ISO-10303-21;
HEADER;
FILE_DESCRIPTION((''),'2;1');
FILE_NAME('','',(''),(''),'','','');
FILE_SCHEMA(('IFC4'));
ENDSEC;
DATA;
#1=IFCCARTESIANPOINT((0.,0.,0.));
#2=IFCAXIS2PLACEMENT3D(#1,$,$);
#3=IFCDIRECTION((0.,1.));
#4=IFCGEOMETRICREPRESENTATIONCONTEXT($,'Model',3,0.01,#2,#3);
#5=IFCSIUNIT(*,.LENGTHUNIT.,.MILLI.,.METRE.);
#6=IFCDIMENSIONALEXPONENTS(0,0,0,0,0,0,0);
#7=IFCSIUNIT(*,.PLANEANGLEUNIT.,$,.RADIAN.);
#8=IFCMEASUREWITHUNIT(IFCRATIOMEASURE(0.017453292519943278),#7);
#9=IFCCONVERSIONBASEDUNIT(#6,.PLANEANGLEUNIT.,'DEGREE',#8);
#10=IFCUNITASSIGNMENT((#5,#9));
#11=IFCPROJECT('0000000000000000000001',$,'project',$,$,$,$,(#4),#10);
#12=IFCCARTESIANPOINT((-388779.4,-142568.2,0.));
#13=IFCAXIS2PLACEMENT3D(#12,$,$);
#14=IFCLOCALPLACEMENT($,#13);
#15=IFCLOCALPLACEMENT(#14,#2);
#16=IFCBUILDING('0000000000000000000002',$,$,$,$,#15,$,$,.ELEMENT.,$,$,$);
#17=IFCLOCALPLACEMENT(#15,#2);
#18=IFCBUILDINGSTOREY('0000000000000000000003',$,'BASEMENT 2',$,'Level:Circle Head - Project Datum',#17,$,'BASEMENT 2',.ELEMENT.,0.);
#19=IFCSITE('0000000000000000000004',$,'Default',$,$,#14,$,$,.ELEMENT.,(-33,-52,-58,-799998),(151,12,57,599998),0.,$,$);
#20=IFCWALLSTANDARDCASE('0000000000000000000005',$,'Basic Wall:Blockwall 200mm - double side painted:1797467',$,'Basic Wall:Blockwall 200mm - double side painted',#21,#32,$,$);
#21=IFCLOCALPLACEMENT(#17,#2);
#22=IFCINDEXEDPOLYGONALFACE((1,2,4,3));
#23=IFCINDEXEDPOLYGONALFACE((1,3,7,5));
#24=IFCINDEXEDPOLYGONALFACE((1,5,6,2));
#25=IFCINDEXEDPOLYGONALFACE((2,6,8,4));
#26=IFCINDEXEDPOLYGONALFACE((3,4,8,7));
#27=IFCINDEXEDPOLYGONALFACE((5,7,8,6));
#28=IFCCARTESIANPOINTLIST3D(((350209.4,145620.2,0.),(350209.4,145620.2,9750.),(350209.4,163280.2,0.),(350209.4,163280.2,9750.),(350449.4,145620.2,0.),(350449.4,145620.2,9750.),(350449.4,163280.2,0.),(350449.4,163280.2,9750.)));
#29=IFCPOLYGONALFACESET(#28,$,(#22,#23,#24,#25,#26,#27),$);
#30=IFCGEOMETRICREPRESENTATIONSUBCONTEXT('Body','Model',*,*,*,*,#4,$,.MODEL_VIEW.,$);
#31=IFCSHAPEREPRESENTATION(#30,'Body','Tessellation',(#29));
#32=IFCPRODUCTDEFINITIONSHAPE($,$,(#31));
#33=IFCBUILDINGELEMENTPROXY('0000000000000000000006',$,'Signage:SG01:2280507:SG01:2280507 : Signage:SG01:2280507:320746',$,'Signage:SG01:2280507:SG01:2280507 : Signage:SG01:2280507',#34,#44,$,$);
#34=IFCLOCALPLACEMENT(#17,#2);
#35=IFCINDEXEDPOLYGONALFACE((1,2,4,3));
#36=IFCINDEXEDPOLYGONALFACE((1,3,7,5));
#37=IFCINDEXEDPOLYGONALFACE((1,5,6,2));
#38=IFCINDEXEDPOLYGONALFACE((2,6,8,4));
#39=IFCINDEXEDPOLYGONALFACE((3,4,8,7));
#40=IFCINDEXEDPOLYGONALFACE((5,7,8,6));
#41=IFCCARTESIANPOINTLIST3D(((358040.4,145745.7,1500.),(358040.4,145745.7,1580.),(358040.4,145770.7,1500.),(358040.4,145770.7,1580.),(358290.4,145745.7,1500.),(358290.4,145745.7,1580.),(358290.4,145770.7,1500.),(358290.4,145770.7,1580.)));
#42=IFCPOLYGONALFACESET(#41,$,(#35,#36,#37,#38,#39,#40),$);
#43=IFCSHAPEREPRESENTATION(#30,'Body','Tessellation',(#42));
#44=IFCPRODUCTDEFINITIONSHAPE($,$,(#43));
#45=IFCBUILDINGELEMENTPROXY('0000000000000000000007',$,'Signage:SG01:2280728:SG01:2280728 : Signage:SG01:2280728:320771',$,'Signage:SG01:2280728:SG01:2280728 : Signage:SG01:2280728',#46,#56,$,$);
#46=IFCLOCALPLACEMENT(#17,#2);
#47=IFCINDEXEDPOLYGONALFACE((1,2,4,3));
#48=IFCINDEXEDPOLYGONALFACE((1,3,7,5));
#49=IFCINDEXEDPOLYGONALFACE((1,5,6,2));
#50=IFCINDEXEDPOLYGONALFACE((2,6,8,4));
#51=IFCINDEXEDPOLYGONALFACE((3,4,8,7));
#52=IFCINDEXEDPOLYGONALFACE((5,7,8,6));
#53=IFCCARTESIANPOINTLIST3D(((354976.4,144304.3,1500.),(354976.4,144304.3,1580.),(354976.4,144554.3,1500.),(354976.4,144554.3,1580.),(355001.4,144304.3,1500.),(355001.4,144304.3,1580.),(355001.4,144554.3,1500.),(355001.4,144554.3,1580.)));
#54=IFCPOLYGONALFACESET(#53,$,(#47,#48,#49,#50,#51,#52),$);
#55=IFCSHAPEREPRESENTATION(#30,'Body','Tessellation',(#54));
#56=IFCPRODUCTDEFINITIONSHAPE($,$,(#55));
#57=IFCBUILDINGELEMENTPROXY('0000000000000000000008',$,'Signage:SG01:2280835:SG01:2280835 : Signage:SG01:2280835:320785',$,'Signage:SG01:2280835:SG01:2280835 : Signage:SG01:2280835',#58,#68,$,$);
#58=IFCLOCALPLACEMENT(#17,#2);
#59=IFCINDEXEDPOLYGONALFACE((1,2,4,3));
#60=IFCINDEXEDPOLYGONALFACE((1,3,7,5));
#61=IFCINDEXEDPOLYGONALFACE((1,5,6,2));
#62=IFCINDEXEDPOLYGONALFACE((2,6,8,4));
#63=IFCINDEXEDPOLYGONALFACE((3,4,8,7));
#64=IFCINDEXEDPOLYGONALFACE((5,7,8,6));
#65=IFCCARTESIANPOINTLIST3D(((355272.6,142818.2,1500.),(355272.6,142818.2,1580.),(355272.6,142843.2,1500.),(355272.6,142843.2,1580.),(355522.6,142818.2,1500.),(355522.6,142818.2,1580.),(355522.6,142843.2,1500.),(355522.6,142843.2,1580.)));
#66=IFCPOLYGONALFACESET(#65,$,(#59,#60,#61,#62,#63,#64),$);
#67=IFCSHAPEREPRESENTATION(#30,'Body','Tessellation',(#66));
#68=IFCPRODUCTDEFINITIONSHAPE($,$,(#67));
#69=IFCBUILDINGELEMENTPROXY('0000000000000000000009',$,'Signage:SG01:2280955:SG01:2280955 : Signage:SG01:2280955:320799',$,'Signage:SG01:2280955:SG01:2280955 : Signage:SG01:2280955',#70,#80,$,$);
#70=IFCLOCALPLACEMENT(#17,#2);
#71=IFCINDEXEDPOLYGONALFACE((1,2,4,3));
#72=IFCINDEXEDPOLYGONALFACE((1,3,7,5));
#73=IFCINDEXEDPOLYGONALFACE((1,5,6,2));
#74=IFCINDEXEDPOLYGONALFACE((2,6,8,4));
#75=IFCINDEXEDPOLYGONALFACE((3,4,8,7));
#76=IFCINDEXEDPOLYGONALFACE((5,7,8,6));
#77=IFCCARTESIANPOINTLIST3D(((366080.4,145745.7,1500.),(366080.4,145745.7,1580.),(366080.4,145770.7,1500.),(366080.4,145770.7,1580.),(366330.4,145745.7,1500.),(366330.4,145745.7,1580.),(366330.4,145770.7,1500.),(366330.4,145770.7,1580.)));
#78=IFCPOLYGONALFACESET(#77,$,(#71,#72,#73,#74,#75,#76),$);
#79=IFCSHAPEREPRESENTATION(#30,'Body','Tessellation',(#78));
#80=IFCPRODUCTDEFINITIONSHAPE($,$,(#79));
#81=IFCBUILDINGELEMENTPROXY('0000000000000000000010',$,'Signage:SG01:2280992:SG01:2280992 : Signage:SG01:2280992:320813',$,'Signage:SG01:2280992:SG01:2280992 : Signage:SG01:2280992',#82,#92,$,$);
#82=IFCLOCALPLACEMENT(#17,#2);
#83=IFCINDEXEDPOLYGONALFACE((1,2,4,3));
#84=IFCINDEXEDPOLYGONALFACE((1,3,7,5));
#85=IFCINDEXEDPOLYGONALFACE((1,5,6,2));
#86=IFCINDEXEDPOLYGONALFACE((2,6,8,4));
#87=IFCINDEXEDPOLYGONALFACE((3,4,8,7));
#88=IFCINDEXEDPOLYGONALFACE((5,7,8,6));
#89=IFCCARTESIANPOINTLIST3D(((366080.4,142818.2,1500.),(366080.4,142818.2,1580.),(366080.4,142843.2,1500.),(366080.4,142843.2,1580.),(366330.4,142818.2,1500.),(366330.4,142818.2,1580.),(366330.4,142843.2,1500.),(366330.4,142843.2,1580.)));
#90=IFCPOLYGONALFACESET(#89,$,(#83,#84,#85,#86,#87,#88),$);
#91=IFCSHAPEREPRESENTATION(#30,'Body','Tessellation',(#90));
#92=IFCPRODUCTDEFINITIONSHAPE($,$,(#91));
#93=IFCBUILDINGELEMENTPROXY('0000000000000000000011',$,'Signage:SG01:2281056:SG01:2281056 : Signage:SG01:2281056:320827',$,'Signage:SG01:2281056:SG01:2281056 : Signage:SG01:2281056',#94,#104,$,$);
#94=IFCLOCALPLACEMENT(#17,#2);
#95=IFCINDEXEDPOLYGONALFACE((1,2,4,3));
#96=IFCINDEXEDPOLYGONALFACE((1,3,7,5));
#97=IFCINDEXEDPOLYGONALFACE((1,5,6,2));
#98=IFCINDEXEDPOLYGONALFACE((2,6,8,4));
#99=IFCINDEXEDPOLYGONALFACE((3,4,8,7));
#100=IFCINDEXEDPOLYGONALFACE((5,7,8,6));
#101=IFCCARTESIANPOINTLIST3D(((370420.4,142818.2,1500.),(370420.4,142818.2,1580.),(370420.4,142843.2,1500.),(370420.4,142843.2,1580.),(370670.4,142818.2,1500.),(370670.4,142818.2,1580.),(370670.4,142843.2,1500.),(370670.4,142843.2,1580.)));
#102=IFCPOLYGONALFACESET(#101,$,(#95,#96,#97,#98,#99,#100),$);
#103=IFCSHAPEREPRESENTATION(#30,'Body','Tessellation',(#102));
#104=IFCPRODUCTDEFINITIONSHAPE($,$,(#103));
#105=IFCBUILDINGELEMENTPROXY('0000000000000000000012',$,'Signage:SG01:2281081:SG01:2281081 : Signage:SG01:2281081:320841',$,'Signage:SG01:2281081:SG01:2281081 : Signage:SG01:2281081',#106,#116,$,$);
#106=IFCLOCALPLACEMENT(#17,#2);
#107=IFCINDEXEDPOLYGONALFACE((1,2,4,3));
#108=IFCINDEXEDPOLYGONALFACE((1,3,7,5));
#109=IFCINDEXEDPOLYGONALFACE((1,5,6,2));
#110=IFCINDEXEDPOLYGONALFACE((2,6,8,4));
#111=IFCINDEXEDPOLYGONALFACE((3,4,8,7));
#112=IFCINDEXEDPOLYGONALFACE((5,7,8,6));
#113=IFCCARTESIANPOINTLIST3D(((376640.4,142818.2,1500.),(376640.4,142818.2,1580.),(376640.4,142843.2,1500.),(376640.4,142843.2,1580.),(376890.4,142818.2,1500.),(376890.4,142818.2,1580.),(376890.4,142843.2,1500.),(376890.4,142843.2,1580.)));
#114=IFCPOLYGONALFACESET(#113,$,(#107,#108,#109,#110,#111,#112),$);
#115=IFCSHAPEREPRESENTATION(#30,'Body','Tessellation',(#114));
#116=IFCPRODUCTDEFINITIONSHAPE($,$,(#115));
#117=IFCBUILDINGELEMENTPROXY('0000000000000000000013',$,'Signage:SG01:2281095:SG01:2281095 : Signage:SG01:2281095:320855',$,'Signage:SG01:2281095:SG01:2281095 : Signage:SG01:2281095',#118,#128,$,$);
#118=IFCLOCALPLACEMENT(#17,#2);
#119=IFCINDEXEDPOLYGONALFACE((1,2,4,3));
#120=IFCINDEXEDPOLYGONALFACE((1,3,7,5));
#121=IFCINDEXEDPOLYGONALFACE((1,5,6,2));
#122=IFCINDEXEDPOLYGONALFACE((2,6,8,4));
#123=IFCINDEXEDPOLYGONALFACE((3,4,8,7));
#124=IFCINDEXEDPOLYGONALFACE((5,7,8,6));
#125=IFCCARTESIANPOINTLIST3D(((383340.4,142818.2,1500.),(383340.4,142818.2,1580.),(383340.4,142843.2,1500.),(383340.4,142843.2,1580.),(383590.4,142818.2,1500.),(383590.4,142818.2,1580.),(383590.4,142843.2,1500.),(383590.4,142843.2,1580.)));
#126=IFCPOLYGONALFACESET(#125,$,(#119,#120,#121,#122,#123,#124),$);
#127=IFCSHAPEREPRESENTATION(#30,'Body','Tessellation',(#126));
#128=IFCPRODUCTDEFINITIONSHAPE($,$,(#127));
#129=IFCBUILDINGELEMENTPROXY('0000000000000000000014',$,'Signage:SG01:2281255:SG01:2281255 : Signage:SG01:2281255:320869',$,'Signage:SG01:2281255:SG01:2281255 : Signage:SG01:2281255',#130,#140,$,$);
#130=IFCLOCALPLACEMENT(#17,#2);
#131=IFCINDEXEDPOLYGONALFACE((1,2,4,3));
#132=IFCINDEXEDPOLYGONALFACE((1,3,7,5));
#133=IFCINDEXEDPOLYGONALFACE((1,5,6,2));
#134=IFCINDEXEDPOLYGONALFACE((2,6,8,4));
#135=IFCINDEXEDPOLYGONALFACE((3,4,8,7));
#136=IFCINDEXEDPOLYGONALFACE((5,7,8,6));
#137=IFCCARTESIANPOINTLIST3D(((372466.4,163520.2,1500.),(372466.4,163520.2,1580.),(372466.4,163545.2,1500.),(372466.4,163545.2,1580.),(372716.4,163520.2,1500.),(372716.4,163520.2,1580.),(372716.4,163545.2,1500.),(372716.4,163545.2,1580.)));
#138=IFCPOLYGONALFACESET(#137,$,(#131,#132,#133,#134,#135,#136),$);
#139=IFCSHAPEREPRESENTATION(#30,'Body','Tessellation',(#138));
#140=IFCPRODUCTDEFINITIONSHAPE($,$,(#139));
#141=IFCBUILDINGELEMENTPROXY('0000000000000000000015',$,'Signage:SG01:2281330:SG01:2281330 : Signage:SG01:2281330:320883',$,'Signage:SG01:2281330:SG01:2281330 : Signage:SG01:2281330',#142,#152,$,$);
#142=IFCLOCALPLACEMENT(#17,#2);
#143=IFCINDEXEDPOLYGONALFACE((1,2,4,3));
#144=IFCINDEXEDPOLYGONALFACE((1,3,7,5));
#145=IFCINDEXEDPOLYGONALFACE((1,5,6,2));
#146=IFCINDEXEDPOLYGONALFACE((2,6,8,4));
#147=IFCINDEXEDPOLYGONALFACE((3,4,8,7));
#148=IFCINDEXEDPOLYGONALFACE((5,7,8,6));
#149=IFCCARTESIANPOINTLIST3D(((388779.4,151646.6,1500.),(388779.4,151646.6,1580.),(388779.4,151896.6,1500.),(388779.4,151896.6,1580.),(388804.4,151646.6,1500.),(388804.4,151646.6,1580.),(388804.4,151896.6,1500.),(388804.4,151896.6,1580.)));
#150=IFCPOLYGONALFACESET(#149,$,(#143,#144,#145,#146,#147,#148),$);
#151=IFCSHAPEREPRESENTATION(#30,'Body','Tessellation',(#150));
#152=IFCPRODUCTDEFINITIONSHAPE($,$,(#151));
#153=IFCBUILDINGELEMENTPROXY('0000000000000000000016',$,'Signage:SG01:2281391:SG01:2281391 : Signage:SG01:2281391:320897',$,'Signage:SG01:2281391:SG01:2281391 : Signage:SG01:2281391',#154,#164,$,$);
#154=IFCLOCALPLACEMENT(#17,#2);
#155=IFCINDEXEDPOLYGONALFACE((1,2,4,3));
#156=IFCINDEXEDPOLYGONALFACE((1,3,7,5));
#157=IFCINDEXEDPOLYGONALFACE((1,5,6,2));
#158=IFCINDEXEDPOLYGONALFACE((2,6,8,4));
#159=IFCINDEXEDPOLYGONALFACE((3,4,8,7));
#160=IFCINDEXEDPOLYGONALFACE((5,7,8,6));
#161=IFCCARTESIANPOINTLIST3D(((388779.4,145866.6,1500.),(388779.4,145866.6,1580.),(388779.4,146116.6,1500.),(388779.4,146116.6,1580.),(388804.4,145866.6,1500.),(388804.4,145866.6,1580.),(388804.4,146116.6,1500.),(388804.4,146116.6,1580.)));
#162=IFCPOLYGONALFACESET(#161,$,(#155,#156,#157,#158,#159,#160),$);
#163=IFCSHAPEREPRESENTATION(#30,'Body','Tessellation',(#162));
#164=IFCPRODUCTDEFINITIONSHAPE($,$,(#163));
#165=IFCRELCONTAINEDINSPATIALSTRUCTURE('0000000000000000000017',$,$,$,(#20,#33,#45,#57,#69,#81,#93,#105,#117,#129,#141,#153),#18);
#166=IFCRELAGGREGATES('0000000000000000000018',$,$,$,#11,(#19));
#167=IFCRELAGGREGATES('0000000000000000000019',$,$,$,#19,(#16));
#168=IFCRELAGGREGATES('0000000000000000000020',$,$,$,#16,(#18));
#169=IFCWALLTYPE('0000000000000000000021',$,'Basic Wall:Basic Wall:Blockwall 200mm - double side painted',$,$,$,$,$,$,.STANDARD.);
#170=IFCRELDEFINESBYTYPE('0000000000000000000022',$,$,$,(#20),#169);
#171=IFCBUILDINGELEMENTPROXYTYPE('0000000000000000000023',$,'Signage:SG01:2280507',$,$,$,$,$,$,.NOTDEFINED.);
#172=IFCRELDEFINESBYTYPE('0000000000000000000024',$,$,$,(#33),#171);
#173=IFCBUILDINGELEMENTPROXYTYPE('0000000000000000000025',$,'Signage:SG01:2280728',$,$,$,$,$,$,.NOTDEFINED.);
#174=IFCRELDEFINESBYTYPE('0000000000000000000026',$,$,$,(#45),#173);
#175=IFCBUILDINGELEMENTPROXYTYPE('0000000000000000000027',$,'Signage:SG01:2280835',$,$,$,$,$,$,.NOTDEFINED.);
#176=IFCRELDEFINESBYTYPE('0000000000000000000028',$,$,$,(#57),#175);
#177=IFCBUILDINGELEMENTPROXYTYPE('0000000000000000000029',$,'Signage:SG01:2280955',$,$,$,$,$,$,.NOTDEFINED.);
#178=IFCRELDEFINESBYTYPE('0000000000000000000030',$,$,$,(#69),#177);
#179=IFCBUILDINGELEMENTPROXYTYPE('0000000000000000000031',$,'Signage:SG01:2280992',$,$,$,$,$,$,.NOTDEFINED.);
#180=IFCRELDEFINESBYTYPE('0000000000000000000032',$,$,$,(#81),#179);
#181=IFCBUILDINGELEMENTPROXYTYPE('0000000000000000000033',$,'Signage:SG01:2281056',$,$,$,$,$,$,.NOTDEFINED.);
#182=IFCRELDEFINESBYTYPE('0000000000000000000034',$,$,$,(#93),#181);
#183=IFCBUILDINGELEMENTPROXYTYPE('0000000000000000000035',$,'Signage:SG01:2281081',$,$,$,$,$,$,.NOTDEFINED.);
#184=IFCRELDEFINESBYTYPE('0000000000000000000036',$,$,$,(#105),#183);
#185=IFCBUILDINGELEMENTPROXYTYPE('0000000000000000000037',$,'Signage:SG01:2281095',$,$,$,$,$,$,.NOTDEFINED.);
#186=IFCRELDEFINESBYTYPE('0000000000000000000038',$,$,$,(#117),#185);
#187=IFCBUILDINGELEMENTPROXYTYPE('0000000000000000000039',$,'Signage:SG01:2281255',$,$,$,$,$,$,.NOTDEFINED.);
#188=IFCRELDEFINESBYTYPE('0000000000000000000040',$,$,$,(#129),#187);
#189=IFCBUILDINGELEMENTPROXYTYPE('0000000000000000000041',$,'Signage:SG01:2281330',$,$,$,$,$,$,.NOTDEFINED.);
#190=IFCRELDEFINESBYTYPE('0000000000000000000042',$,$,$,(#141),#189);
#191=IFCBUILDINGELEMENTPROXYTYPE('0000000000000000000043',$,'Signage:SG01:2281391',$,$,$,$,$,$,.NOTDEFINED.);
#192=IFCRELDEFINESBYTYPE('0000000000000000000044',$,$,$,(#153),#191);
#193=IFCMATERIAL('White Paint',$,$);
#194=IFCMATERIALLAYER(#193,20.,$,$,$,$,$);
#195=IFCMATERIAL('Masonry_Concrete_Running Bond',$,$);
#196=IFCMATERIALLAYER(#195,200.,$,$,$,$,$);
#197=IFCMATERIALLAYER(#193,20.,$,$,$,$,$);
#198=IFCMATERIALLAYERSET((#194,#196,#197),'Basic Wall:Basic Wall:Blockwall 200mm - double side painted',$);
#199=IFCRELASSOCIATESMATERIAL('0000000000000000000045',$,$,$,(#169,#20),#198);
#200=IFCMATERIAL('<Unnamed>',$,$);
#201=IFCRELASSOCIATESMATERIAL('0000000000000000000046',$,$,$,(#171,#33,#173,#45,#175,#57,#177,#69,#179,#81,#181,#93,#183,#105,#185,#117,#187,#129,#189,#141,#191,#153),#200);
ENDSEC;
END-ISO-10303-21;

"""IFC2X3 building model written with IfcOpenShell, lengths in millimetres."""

from ifc_helpers import new_model, entity, si_unit, converted_unit, direction, frame, frame_2d, origin, origin_2d_with_axis, place, context, subcontext, project, spatial, rectangle, extrude, source, transform, mapped, material, layer, layer_set, layer_usage, type_object, type_shapes, element, save


model = new_model("IFC2X3")

# Units and contexts
model_context = context("Model", 3, precision=0.01, world=origin(), true_north=direction((0.0, 1.0)))
body_context = subcontext(model_context, "Body", "Model", "MODEL_VIEW")
ifc_project = project(units=[si_unit("LENGTHUNIT", "METRE", prefix="MILLI"), converted_unit("PLANEANGLEUNIT", "DEGREE", entity("IfcRatioMeasure", 0.017453292519943278), si_unit("PLANEANGLEUNIT", "RADIAN"), dimensions=[0, 0, 0, 0, 0, 0, 0])], contexts=[model_context])

# Site, building, storey
site_placement = place(None, frame((-388779.4, -142568.2, 0.0)))
site = spatial("IfcSite", under=ifc_project, at=site_placement, Name="Default", CompositionType="ELEMENT", RefLatitude=(-33, -52, -58, -799998), RefLongitude=(151, 12, 57, 599998), RefElevation=0.0)
building_placement = place(site_placement, origin())
building = spatial("IfcBuilding", under=site, at=building_placement, CompositionType="ELEMENT")
storey_placement = place(building_placement, origin())
storey = spatial("IfcBuildingStorey", under=building, at=storey_placement, Name="BASEMENT 2", ObjectType="Level:Circle Head - Project Datum", LongName="BASEMENT 2", CompositionType="ELEMENT", Elevation=0.0)

# Shared definitions
ifc_material_1 = material(Name="White Paint")

# Wall
ifc_layer_1 = layer(ifc_material_1, 20.0)
ifc_material_2 = material(Name="Masonry_Concrete_Running Bond")
ifc_layer_2 = layer(ifc_material_2, 200.0)
ifc_layer_3 = layer(ifc_material_1, 20.0)
ifc_layer_set_1 = layer_set([ifc_layer_1, ifc_layer_2, ifc_layer_3], Name="Basic Wall:Basic Wall:Blockwall 200mm - double side painted")
ifc_layer_usage_1 = layer_usage(ifc_layer_set_1, "AXIS2", "NEGATIVE", 120.0)
wall_type_1 = type_object("IfcWallType", Name="Basic Wall:Basic Wall:Blockwall 200mm - double side painted", PredefinedType="STANDARD", material=ifc_layer_set_1)
wall_1_placement = place(storey_placement, frame((350329.4, 145620.2, 0.0), z_axis=(0.0, 0.0, 1.0), x_axis=(0.0, 1.0, 0.0)))
element("IfcWallStandardCase", 1, at=wall_1_placement, inside=storey, type_object=wall_type_1, material=ifc_layer_usage_1, Name="Basic Wall:Blockwall 200mm - double side painted:1797467", ObjectType="Basic Wall:Blockwall 200mm - double side painted", context=body_context, shape_type="SweptSolid", body=[
    extrude(rectangle(XDim=17660.0, YDim=240.0, at=frame_2d((8830.0, 0.0), x_axis=(-1.0, 0.0))), origin(), (0.0, 0.0, 1.0), 9750.0),
])

# Building element proxies
ifc_material_3 = material(Name="<Unnamed>")
building_element_proxy_type_1 = type_object("IfcBuildingElementProxyType", Name="Signage:SG01:2280507", PredefinedType="NOTDEFINED", material=ifc_material_3)
shared_shape_1 = source(origin(), body_context, "Body", "SweptSolid", [
    extrude(rectangle(XDim=25.0, YDim=250.0, at=origin_2d_with_axis()), frame((358165.4, 145758.2, 1500.0), z_axis=(0.0, 0.0, 1.0), x_axis=(0.0, -1.0, 0.0)), (0.0, 0.0, 1.0), 80.0),
])
type_shapes(building_element_proxy_type_1, [shared_shape_1])
proxy_1_placement = place(storey_placement, origin())
element("IfcBuildingElementProxy", 2, at=proxy_1_placement, inside=storey, type_object=building_element_proxy_type_1, material=ifc_material_3, Name="Signage:SG01:2280507:SG01:2280507 : Signage:SG01:2280507:320746", ObjectType="Signage:SG01:2280507:SG01:2280507 : Signage:SG01:2280507", context=body_context, shape_type="MappedRepresentation", body=[
    mapped(shared_shape_1, transform((0.0, 0.0, 0.0), scale=1.0)),
])
building_element_proxy_type_2 = type_object("IfcBuildingElementProxyType", Name="Signage:SG01:2280728", PredefinedType="NOTDEFINED", material=ifc_material_3)
shared_shape_2 = source(origin(), body_context, "Body", "SweptSolid", [
    extrude(rectangle(XDim=25.0, YDim=250.0, at=frame_2d((0.0, 0.0), x_axis=(1.0, 0.0))), frame((354988.9, 144429.3, 1500.0)), (0.0, 0.0, 1.0), 80.0),
])
type_shapes(building_element_proxy_type_2, [shared_shape_2])
proxy_2_placement = place(storey_placement, origin())
element("IfcBuildingElementProxy", 3, at=proxy_2_placement, inside=storey, type_object=building_element_proxy_type_2, material=ifc_material_3, Name="Signage:SG01:2280728:SG01:2280728 : Signage:SG01:2280728:320771", ObjectType="Signage:SG01:2280728:SG01:2280728 : Signage:SG01:2280728", context=body_context, shape_type="MappedRepresentation", body=[
    mapped(shared_shape_2, transform((0.0, 0.0, 0.0), scale=1.0)),
])
building_element_proxy_type_3 = type_object("IfcBuildingElementProxyType", Name="Signage:SG01:2280835", PredefinedType="NOTDEFINED", material=ifc_material_3)
shared_shape_3 = source(origin(), body_context, "Body", "SweptSolid", [
    extrude(rectangle(XDim=25.0, YDim=250.0, at=frame_2d((0.0, 0.0), x_axis=(1.0, 0.0))), frame((355397.6, 142830.7, 1500.0), z_axis=(0.0, 0.0, 1.0), x_axis=(0.0, 1.0, 0.0)), (0.0, 0.0, 1.0), 80.0),
])
type_shapes(building_element_proxy_type_3, [shared_shape_3])
proxy_3_placement = place(storey_placement, origin())
element("IfcBuildingElementProxy", 4, at=proxy_3_placement, inside=storey, type_object=building_element_proxy_type_3, material=ifc_material_3, Name="Signage:SG01:2280835:SG01:2280835 : Signage:SG01:2280835:320785", ObjectType="Signage:SG01:2280835:SG01:2280835 : Signage:SG01:2280835", context=body_context, shape_type="MappedRepresentation", body=[
    mapped(shared_shape_3, transform((0.0, 0.0, 0.0), scale=1.0)),
])
building_element_proxy_type_4 = type_object("IfcBuildingElementProxyType", Name="Signage:SG01:2280955", PredefinedType="NOTDEFINED", material=ifc_material_3)
shared_shape_4 = source(origin(), body_context, "Body", "SweptSolid", [
    extrude(rectangle(XDim=25.0, YDim=250.0, at=origin_2d_with_axis()), frame((366205.4, 145758.2, 1500.0), z_axis=(0.0, 0.0, 1.0), x_axis=(0.0, -1.0, 0.0)), (0.0, 0.0, 1.0), 80.0),
])
type_shapes(building_element_proxy_type_4, [shared_shape_4])
proxy_4_placement = place(storey_placement, origin())
element("IfcBuildingElementProxy", 5, at=proxy_4_placement, inside=storey, type_object=building_element_proxy_type_4, material=ifc_material_3, Name="Signage:SG01:2280955:SG01:2280955 : Signage:SG01:2280955:320799", ObjectType="Signage:SG01:2280955:SG01:2280955 : Signage:SG01:2280955", context=body_context, shape_type="MappedRepresentation", body=[
    mapped(shared_shape_4, transform((0.0, 0.0, 0.0), scale=1.0)),
])
building_element_proxy_type_5 = type_object("IfcBuildingElementProxyType", Name="Signage:SG01:2280992", PredefinedType="NOTDEFINED", material=ifc_material_3)
shared_shape_5 = source(origin(), body_context, "Body", "SweptSolid", [
    extrude(rectangle(XDim=25.0, YDim=250.0, at=frame_2d((0.0, 0.0), x_axis=(1.0, 0.0))), frame((366205.4, 142830.7, 1500.0), z_axis=(0.0, 0.0, 1.0), x_axis=(0.0, 1.0, 0.0)), (0.0, 0.0, 1.0), 80.0),
])
type_shapes(building_element_proxy_type_5, [shared_shape_5])
proxy_5_placement = place(storey_placement, origin())
element("IfcBuildingElementProxy", 6, at=proxy_5_placement, inside=storey, type_object=building_element_proxy_type_5, material=ifc_material_3, Name="Signage:SG01:2280992:SG01:2280992 : Signage:SG01:2280992:320813", ObjectType="Signage:SG01:2280992:SG01:2280992 : Signage:SG01:2280992", context=body_context, shape_type="MappedRepresentation", body=[
    mapped(shared_shape_5, transform((0.0, 0.0, 0.0), scale=1.0)),
])
building_element_proxy_type_6 = type_object("IfcBuildingElementProxyType", Name="Signage:SG01:2281056", PredefinedType="NOTDEFINED", material=ifc_material_3)
shared_shape_6 = source(origin(), body_context, "Body", "SweptSolid", [
    extrude(rectangle(XDim=25.0, YDim=250.0, at=frame_2d((0.0, 0.0), x_axis=(1.0, 0.0))), frame((370545.4, 142830.7, 1500.0), z_axis=(0.0, 0.0, 1.0), x_axis=(0.0, 1.0, 0.0)), (0.0, 0.0, 1.0), 80.0),
])
type_shapes(building_element_proxy_type_6, [shared_shape_6])
proxy_6_placement = place(storey_placement, origin())
element("IfcBuildingElementProxy", 7, at=proxy_6_placement, inside=storey, type_object=building_element_proxy_type_6, material=ifc_material_3, Name="Signage:SG01:2281056:SG01:2281056 : Signage:SG01:2281056:320827", ObjectType="Signage:SG01:2281056:SG01:2281056 : Signage:SG01:2281056", context=body_context, shape_type="MappedRepresentation", body=[
    mapped(shared_shape_6, transform((0.0, 0.0, 0.0), scale=1.0)),
])
building_element_proxy_type_7 = type_object("IfcBuildingElementProxyType", Name="Signage:SG01:2281081", PredefinedType="NOTDEFINED", material=ifc_material_3)
shared_shape_7 = source(origin(), body_context, "Body", "SweptSolid", [
    extrude(rectangle(XDim=25.0, YDim=250.0, at=frame_2d((0.0, 0.0), x_axis=(1.0, 0.0))), frame((376765.4, 142830.7, 1500.0), z_axis=(0.0, 0.0, 1.0), x_axis=(0.0, 1.0, 0.0)), (0.0, 0.0, 1.0), 80.0),
])
type_shapes(building_element_proxy_type_7, [shared_shape_7])
proxy_7_placement = place(storey_placement, origin())
element("IfcBuildingElementProxy", 8, at=proxy_7_placement, inside=storey, type_object=building_element_proxy_type_7, material=ifc_material_3, Name="Signage:SG01:2281081:SG01:2281081 : Signage:SG01:2281081:320841", ObjectType="Signage:SG01:2281081:SG01:2281081 : Signage:SG01:2281081", context=body_context, shape_type="MappedRepresentation", body=[
    mapped(shared_shape_7, transform((0.0, 0.0, 0.0), scale=1.0)),
])
building_element_proxy_type_8 = type_object("IfcBuildingElementProxyType", Name="Signage:SG01:2281095", PredefinedType="NOTDEFINED", material=ifc_material_3)
shared_shape_8 = source(origin(), body_context, "Body", "SweptSolid", [
    extrude(rectangle(XDim=25.0, YDim=250.0, at=frame_2d((0.0, 0.0), x_axis=(1.0, 0.0))), frame((383465.4, 142830.7, 1500.0), z_axis=(0.0, 0.0, 1.0), x_axis=(0.0, 1.0, 0.0)), (0.0, 0.0, 1.0), 80.0),
])
type_shapes(building_element_proxy_type_8, [shared_shape_8])
proxy_8_placement = place(storey_placement, origin())
element("IfcBuildingElementProxy", 9, at=proxy_8_placement, inside=storey, type_object=building_element_proxy_type_8, material=ifc_material_3, Name="Signage:SG01:2281095:SG01:2281095 : Signage:SG01:2281095:320855", ObjectType="Signage:SG01:2281095:SG01:2281095 : Signage:SG01:2281095", context=body_context, shape_type="MappedRepresentation", body=[
    mapped(shared_shape_8, transform((0.0, 0.0, 0.0), scale=1.0)),
])
building_element_proxy_type_9 = type_object("IfcBuildingElementProxyType", Name="Signage:SG01:2281255", PredefinedType="NOTDEFINED", material=ifc_material_3)
shared_shape_9 = source(origin(), body_context, "Body", "SweptSolid", [
    extrude(rectangle(XDim=25.0, YDim=250.0, at=origin_2d_with_axis()), frame((372591.4, 163532.7, 1500.0), z_axis=(0.0, 0.0, 1.0), x_axis=(0.0, 1.0, 0.0)), (0.0, 0.0, 1.0), 80.0),
])
type_shapes(building_element_proxy_type_9, [shared_shape_9])
proxy_9_placement = place(storey_placement, origin())
element("IfcBuildingElementProxy", 10, at=proxy_9_placement, inside=storey, type_object=building_element_proxy_type_9, material=ifc_material_3, Name="Signage:SG01:2281255:SG01:2281255 : Signage:SG01:2281255:320869", ObjectType="Signage:SG01:2281255:SG01:2281255 : Signage:SG01:2281255", context=body_context, shape_type="MappedRepresentation", body=[
    mapped(shared_shape_9, transform((0.0, 0.0, 0.0), scale=1.0)),
])
building_element_proxy_type_10 = type_object("IfcBuildingElementProxyType", Name="Signage:SG01:2281330", PredefinedType="NOTDEFINED", material=ifc_material_3)
shared_shape_10 = source(origin(), body_context, "Body", "SweptSolid", [
    extrude(rectangle(XDim=25.0, YDim=250.0, at=origin_2d_with_axis()), frame((388791.9, 151771.6, 1500.0)), (0.0, 0.0, 1.0), 80.0),
])
type_shapes(building_element_proxy_type_10, [shared_shape_10])
proxy_10_placement = place(storey_placement, origin())
element("IfcBuildingElementProxy", 11, at=proxy_10_placement, inside=storey, type_object=building_element_proxy_type_10, material=ifc_material_3, Name="Signage:SG01:2281330:SG01:2281330 : Signage:SG01:2281330:320883", ObjectType="Signage:SG01:2281330:SG01:2281330 : Signage:SG01:2281330", context=body_context, shape_type="MappedRepresentation", body=[
    mapped(shared_shape_10, transform((0.0, 0.0, 0.0), scale=1.0)),
])
building_element_proxy_type_11 = type_object("IfcBuildingElementProxyType", Name="Signage:SG01:2281391", PredefinedType="NOTDEFINED", material=ifc_material_3)
shared_shape_11 = source(origin(), body_context, "Body", "SweptSolid", [
    extrude(rectangle(XDim=25.0, YDim=250.0, at=frame_2d((0.0, 0.0), x_axis=(1.0, 0.0))), frame((388791.9, 145991.6, 1500.0)), (0.0, 0.0, 1.0), 80.0),
])
type_shapes(building_element_proxy_type_11, [shared_shape_11])
proxy_11_placement = place(storey_placement, origin())
element("IfcBuildingElementProxy", 12, at=proxy_11_placement, inside=storey, type_object=building_element_proxy_type_11, material=ifc_material_3, Name="Signage:SG01:2281391:SG01:2281391 : Signage:SG01:2281391:320897", ObjectType="Signage:SG01:2281391:SG01:2281391 : Signage:SG01:2281391", context=body_context, shape_type="MappedRepresentation", body=[
    mapped(shared_shape_11, transform((0.0, 0.0, 0.0), scale=1.0)),
])

save(model, "model.ifc")
